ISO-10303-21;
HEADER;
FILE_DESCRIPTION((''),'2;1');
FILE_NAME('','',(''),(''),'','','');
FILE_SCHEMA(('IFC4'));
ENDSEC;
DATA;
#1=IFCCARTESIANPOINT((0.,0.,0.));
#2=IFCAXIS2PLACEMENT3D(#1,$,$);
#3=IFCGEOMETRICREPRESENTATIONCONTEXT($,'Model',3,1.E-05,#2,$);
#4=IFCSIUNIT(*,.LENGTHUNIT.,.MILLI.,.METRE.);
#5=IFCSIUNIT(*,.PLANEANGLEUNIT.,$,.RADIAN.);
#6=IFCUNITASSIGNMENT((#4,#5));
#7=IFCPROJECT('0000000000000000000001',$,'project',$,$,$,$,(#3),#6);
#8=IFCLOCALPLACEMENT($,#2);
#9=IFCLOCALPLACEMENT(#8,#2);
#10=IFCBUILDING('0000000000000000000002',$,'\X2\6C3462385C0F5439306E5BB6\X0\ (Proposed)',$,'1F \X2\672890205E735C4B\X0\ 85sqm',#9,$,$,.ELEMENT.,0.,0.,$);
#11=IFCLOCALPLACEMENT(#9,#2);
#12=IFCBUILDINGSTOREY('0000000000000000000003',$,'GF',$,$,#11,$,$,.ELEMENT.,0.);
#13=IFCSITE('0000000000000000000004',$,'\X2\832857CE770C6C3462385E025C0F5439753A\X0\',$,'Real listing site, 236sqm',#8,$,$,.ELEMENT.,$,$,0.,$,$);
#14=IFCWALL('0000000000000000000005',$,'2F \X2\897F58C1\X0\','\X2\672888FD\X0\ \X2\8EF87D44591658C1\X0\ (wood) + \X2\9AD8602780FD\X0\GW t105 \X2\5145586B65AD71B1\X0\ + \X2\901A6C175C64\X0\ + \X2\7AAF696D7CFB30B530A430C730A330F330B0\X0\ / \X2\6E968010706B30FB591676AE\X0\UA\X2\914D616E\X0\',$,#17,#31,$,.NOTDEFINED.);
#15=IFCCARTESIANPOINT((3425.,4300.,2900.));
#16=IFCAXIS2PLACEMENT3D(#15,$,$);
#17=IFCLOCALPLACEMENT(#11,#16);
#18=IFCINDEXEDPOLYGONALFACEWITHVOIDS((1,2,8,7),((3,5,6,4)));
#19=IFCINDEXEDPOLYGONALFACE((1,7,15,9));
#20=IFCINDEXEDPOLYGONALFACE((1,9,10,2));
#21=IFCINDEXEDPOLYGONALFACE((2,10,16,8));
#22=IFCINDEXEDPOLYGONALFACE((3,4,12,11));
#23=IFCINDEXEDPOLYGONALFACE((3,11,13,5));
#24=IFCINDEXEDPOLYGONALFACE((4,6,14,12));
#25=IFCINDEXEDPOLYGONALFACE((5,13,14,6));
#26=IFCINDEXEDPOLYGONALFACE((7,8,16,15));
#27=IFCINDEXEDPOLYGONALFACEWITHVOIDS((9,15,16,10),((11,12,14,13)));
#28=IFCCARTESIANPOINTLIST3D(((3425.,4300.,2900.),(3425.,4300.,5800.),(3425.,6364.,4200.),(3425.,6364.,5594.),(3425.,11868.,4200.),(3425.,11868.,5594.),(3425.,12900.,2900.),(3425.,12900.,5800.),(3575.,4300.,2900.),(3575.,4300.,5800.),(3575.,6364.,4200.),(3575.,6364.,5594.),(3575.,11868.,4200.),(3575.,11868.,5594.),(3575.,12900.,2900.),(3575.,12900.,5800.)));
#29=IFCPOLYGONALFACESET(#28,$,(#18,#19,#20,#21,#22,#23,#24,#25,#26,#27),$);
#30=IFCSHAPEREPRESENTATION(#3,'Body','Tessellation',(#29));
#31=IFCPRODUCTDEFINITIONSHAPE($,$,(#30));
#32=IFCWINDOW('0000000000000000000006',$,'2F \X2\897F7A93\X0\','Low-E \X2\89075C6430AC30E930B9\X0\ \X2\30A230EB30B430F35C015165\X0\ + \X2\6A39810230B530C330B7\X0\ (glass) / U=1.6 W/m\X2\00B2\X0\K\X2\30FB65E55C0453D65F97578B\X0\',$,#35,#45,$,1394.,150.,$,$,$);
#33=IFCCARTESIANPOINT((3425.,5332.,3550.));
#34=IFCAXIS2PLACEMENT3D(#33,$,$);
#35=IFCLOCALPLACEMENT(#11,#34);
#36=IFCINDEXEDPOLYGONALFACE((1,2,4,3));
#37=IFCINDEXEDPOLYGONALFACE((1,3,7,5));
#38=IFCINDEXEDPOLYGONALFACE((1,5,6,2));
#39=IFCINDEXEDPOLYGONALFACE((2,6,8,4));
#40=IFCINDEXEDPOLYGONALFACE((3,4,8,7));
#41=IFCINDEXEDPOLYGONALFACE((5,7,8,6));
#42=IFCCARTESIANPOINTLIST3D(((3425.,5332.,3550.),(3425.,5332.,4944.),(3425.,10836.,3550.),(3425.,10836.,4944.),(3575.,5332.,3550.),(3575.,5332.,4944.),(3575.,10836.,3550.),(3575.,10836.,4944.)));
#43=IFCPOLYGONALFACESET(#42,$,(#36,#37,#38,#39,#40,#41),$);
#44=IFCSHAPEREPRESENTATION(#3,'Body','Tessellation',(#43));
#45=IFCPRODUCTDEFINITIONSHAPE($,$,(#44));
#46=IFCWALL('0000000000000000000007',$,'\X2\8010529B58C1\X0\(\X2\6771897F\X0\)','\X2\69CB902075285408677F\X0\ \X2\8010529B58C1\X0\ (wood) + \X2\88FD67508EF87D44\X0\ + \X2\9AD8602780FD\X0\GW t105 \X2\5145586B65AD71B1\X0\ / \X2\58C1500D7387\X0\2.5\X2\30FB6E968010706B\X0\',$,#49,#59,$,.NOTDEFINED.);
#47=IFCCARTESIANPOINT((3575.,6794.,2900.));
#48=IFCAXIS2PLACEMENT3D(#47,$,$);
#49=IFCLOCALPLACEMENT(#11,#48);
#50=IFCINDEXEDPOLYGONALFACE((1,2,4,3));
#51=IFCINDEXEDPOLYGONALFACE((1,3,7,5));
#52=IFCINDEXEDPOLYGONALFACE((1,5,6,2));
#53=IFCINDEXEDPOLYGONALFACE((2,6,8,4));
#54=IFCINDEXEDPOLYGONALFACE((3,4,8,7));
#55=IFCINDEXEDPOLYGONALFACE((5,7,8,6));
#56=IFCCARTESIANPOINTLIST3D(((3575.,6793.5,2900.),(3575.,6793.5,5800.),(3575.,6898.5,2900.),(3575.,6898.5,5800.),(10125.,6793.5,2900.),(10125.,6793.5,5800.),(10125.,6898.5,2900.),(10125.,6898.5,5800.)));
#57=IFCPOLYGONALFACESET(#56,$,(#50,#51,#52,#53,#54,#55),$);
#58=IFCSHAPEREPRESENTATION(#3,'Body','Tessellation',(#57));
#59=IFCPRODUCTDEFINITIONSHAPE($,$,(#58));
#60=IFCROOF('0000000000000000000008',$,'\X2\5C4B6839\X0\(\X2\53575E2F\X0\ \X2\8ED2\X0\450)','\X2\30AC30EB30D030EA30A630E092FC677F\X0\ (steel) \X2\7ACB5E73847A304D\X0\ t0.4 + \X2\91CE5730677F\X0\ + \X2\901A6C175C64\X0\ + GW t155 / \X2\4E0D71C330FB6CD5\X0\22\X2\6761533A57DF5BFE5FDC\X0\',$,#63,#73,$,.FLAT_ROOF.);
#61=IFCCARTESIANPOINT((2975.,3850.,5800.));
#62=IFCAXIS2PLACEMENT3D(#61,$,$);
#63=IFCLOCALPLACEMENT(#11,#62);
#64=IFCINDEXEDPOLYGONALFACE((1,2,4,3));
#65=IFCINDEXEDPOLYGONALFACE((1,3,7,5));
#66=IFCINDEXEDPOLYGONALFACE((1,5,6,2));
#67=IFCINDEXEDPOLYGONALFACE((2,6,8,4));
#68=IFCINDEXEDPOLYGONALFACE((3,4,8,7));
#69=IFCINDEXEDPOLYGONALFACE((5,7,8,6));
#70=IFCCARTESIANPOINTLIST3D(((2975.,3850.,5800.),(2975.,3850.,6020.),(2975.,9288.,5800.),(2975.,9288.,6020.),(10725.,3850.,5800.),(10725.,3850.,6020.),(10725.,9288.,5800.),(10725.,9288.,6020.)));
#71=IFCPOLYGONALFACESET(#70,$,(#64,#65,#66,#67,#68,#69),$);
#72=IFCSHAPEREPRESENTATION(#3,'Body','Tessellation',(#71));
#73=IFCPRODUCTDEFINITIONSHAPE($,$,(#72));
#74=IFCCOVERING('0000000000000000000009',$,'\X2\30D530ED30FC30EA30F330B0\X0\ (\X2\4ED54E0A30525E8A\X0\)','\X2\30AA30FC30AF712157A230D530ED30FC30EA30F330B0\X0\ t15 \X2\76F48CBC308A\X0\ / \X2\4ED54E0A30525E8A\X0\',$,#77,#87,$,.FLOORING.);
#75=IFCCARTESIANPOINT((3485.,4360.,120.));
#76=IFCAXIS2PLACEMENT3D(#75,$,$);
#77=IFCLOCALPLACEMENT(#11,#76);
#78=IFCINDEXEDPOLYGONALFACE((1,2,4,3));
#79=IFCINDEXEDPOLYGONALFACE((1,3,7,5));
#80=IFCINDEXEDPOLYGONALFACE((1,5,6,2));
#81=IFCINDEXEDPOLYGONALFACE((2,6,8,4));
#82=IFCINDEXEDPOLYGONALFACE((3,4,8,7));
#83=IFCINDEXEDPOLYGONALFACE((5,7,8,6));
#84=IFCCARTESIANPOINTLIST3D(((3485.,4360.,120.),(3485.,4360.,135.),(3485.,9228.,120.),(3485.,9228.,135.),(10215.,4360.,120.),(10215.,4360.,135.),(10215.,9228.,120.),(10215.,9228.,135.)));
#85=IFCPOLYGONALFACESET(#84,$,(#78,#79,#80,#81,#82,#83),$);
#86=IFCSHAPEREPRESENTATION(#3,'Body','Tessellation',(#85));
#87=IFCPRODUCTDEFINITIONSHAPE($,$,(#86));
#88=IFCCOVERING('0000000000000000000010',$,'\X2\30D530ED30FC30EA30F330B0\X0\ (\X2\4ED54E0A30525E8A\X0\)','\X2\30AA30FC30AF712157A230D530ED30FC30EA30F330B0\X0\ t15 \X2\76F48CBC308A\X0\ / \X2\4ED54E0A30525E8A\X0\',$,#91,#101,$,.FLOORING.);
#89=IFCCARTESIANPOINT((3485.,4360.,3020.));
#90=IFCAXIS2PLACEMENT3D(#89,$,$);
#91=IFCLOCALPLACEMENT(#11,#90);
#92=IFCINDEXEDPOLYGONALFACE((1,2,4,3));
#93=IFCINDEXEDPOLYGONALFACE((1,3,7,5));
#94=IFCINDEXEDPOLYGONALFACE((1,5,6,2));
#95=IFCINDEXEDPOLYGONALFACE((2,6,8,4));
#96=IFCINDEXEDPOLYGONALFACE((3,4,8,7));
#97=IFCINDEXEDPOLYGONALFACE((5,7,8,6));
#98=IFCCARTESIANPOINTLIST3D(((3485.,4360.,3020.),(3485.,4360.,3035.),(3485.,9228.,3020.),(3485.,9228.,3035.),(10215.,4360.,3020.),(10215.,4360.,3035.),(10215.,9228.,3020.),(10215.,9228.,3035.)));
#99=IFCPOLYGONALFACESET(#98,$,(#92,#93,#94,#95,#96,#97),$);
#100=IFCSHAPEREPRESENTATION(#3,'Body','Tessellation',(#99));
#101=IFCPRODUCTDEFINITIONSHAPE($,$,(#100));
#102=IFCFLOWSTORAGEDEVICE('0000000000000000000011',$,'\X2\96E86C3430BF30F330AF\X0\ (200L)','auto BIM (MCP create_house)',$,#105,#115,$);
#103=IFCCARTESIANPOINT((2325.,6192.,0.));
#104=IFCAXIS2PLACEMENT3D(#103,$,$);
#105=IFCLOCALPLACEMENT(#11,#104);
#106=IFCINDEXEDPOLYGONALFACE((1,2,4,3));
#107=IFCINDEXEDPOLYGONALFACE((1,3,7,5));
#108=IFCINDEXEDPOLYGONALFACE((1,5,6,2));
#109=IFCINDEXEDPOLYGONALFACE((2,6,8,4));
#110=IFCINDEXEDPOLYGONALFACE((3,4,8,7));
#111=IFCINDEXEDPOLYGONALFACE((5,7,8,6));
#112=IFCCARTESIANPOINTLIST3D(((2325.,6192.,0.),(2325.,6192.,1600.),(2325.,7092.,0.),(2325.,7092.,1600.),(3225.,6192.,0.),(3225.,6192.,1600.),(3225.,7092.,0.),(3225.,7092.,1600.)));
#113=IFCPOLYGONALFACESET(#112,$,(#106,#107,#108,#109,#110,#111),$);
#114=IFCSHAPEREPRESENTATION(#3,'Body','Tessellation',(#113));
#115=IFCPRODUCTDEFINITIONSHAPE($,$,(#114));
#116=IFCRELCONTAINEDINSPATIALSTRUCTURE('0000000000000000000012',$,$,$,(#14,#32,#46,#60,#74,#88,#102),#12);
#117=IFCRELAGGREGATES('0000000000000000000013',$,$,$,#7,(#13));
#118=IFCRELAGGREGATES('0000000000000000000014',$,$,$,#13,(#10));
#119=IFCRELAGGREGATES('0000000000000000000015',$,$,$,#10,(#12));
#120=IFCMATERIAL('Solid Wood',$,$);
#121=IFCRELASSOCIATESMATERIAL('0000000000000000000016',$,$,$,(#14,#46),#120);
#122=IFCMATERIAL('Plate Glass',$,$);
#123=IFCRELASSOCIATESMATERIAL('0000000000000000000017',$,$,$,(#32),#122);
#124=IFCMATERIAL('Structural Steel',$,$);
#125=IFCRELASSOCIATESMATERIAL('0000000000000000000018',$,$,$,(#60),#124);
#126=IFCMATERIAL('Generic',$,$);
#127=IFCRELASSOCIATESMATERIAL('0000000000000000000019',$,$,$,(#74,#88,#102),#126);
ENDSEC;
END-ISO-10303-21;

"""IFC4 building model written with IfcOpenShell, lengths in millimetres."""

from ifc_helpers import new_model, si_unit, frame, frame_2d, origin, place, context, project, spatial, rectangle, extrude, material, element, fill, save


model = new_model("IFC4")

# Units and contexts
model_context = context("Model", 3, precision=1e-05, world=origin())
ifc_project = project(units=[si_unit("LENGTHUNIT", "METRE", prefix="MILLI"), si_unit("PLANEANGLEUNIT", "RADIAN")], contexts=[model_context])

# Site, building, storey
site_placement = place(None, origin())
site = spatial("IfcSite", under=ifc_project, at=site_placement, Name="茨城県水戸市小吹町", ObjectType="Real listing site, 236sqm", CompositionType="ELEMENT", RefElevation=0.0)
building_placement = place(site_placement, origin())
building = spatial("IfcBuilding", under=site, at=building_placement, Name="水戸小吹の家 (Proposed)", ObjectType="1F 木造平屋 85sqm", CompositionType="ELEMENT", ElevationOfRefHeight=0.0, ElevationOfTerrain=0.0)
storey_placement = place(building_placement, origin())
storey = spatial("IfcBuildingStorey", under=building, at=storey_placement, Name="GF", CompositionType="ELEMENT", Elevation=0.0)

# Shared definitions
ifc_material_1 = material(Name="Solid Wood")
ifc_material_2 = material(Name="Generic")

# Shared definitions
ifc_material_3 = material(Name="Plate Glass")

# Wall, opening, window
wall_1_placement = place(storey_placement, frame((3425.0, 4300.0, 2900.0)))
wall_1 = element("IfcWall", 1, at=wall_1_placement, inside=storey, material=ifc_material_1, Name="2F 西壁", Description="木製 軸組外壁 (wood) + 高性能GW t105 充填断熱 + 通気層 + 窯業系サイディング / 準耐火・外皮UA配慮", PredefinedType="NOTDEFINED", context=model_context, shape_type="SweptSolid", body=[
    extrude(rectangle(XDim=150.0, YDim=8600.0, at=frame_2d((75.0, 4300.0))), frame((3425.0, 4300.0, 2900.0)), (0.0, 0.0, 1.0), 2900.0),
])
opening_1_placement = place(storey_placement, frame((3425.0, 5332.0, 3550.0)))
opening_1 = element("IfcOpeningElement", 2, at=opening_1_placement, cuts=wall_1, PredefinedType="NOTDEFINED", context=model_context, shape_type="SweptSolid", body=[
    extrude(rectangle(XDim=150.0, YDim=5504.0, at=frame_2d((75.0, 2752.0))), frame((3425.0, 5332.0, 3550.0)), (0.0, 0.0, 1.0), 1394.0),
])
window_1_placement = place(storey_placement, frame((3425.0, 5332.0, 3550.0)))
window_1 = element("IfcWindow", 3, at=window_1_placement, inside=storey, material=ifc_material_3, Name="2F 西窓", Description="Low-E 複層ガラス アルゴン封入 + 樹脂サッシ (glass) / U=1.6 W/m²K・日射取得型", OverallHeight=1394.0, OverallWidth=150.0, context=model_context, shape_type="SweptSolid", body=[
    extrude(rectangle(XDim=150.0, YDim=5504.0, at=frame_2d((75.0, 2752.0))), frame((3425.0, 5332.0, 3550.0)), (0.0, 0.0, 1.0), 1394.0),
])
fill(opening_1, window_1)

# Wall
wall_2_placement = place(storey_placement, frame((3575.0, 6794.0, 2900.0)))
element("IfcWall", 4, at=wall_2_placement, inside=storey, material=ifc_material_1, Name="耐力壁(東西)", Description="構造用合板 耐力壁 (wood) + 製材軸組 + 高性能GW t105 充填断熱 / 壁倍率2.5・準耐火", PredefinedType="NOTDEFINED", context=model_context, shape_type="SweptSolid", body=[
    extrude(rectangle(XDim=6550.0, YDim=105.0, at=frame_2d((3275.0, 52.0))), frame((3575.0, 6794.0, 2900.0)), (0.0, 0.0, 1.0), 2900.0),
])

# Roof
ifc_material_4 = material(Name="Structural Steel")
for number, where, name in (
    (5, (2975.0, 3850.0, 5800.0), "屋根(南帯 軒450)"),
):
    element("IfcRoof", number, at=place(storey_placement, frame(where)), inside=storey, material=ifc_material_4, Name=name, Description="ガルバリウム鋼板 (steel) 立平葺き t0.4 + 野地板 + 通気層 + GW t155 / 不燃・法22条区域対応", PredefinedType="FLAT_ROOF", context=model_context, shape_type="SweptSolid", body=[
        extrude(rectangle(XDim=7750.0, YDim=5438.0, at=frame_2d((3875.0, 2719.0))), frame((2975.0, 3850.0, 5800.0)), (0.0, 0.0, 1.0), 220.0),
    ])

# Coverings
covering_1_placement = place(storey_placement, frame((3485.0, 4360.0, 120.0)))
element("IfcCovering", 6, at=covering_1_placement, inside=storey, material=ifc_material_2, Name="フローリング (仕上げ床)", Description="オーク無垢フローリング t15 直貼り / 仕上げ床", PredefinedType="FLOORING", context=model_context, shape_type="SweptSolid", body=[
    extrude(rectangle(XDim=6730.0, YDim=4868.0, at=frame_2d((3365.0, 2434.0))), frame((3485.0, 4360.0, 120.0)), (0.0, 0.0, 1.0), 15.0),
])
covering_2_placement = place(storey_placement, frame((3485.0, 4360.0, 3020.0)))
element("IfcCovering", 7, at=covering_2_placement, inside=storey, material=ifc_material_2, Name="フローリング (仕上げ床)", Description="オーク無垢フローリング t15 直貼り / 仕上げ床", PredefinedType="FLOORING", context=model_context, shape_type="SweptSolid", body=[
    extrude(rectangle(XDim=6730.0, YDim=4868.0, at=frame_2d((3365.0, 2434.0))), frame((3485.0, 4360.0, 3020.0)), (0.0, 0.0, 1.0), 15.0),
])

# Flow storage device
flow_storage_device_placement = place(storey_placement, frame((2325.0, 6192.0, 0.0)))
element("IfcFlowStorageDevice", 8, at=flow_storage_device_placement, inside=storey, material=ifc_material_2, Name="雨水タンク (200L)", Description="auto BIM (MCP create_house)", context=model_context, shape_type="SweptSolid", body=[
    extrude(rectangle(XDim=900.0, YDim=900.0, at=frame_2d((450.0, 450.0))), frame((2325.0, 6192.0, 0.0)), (0.0, 0.0, 1.0), 1600.0),
])

save(model, "model.ifc")
